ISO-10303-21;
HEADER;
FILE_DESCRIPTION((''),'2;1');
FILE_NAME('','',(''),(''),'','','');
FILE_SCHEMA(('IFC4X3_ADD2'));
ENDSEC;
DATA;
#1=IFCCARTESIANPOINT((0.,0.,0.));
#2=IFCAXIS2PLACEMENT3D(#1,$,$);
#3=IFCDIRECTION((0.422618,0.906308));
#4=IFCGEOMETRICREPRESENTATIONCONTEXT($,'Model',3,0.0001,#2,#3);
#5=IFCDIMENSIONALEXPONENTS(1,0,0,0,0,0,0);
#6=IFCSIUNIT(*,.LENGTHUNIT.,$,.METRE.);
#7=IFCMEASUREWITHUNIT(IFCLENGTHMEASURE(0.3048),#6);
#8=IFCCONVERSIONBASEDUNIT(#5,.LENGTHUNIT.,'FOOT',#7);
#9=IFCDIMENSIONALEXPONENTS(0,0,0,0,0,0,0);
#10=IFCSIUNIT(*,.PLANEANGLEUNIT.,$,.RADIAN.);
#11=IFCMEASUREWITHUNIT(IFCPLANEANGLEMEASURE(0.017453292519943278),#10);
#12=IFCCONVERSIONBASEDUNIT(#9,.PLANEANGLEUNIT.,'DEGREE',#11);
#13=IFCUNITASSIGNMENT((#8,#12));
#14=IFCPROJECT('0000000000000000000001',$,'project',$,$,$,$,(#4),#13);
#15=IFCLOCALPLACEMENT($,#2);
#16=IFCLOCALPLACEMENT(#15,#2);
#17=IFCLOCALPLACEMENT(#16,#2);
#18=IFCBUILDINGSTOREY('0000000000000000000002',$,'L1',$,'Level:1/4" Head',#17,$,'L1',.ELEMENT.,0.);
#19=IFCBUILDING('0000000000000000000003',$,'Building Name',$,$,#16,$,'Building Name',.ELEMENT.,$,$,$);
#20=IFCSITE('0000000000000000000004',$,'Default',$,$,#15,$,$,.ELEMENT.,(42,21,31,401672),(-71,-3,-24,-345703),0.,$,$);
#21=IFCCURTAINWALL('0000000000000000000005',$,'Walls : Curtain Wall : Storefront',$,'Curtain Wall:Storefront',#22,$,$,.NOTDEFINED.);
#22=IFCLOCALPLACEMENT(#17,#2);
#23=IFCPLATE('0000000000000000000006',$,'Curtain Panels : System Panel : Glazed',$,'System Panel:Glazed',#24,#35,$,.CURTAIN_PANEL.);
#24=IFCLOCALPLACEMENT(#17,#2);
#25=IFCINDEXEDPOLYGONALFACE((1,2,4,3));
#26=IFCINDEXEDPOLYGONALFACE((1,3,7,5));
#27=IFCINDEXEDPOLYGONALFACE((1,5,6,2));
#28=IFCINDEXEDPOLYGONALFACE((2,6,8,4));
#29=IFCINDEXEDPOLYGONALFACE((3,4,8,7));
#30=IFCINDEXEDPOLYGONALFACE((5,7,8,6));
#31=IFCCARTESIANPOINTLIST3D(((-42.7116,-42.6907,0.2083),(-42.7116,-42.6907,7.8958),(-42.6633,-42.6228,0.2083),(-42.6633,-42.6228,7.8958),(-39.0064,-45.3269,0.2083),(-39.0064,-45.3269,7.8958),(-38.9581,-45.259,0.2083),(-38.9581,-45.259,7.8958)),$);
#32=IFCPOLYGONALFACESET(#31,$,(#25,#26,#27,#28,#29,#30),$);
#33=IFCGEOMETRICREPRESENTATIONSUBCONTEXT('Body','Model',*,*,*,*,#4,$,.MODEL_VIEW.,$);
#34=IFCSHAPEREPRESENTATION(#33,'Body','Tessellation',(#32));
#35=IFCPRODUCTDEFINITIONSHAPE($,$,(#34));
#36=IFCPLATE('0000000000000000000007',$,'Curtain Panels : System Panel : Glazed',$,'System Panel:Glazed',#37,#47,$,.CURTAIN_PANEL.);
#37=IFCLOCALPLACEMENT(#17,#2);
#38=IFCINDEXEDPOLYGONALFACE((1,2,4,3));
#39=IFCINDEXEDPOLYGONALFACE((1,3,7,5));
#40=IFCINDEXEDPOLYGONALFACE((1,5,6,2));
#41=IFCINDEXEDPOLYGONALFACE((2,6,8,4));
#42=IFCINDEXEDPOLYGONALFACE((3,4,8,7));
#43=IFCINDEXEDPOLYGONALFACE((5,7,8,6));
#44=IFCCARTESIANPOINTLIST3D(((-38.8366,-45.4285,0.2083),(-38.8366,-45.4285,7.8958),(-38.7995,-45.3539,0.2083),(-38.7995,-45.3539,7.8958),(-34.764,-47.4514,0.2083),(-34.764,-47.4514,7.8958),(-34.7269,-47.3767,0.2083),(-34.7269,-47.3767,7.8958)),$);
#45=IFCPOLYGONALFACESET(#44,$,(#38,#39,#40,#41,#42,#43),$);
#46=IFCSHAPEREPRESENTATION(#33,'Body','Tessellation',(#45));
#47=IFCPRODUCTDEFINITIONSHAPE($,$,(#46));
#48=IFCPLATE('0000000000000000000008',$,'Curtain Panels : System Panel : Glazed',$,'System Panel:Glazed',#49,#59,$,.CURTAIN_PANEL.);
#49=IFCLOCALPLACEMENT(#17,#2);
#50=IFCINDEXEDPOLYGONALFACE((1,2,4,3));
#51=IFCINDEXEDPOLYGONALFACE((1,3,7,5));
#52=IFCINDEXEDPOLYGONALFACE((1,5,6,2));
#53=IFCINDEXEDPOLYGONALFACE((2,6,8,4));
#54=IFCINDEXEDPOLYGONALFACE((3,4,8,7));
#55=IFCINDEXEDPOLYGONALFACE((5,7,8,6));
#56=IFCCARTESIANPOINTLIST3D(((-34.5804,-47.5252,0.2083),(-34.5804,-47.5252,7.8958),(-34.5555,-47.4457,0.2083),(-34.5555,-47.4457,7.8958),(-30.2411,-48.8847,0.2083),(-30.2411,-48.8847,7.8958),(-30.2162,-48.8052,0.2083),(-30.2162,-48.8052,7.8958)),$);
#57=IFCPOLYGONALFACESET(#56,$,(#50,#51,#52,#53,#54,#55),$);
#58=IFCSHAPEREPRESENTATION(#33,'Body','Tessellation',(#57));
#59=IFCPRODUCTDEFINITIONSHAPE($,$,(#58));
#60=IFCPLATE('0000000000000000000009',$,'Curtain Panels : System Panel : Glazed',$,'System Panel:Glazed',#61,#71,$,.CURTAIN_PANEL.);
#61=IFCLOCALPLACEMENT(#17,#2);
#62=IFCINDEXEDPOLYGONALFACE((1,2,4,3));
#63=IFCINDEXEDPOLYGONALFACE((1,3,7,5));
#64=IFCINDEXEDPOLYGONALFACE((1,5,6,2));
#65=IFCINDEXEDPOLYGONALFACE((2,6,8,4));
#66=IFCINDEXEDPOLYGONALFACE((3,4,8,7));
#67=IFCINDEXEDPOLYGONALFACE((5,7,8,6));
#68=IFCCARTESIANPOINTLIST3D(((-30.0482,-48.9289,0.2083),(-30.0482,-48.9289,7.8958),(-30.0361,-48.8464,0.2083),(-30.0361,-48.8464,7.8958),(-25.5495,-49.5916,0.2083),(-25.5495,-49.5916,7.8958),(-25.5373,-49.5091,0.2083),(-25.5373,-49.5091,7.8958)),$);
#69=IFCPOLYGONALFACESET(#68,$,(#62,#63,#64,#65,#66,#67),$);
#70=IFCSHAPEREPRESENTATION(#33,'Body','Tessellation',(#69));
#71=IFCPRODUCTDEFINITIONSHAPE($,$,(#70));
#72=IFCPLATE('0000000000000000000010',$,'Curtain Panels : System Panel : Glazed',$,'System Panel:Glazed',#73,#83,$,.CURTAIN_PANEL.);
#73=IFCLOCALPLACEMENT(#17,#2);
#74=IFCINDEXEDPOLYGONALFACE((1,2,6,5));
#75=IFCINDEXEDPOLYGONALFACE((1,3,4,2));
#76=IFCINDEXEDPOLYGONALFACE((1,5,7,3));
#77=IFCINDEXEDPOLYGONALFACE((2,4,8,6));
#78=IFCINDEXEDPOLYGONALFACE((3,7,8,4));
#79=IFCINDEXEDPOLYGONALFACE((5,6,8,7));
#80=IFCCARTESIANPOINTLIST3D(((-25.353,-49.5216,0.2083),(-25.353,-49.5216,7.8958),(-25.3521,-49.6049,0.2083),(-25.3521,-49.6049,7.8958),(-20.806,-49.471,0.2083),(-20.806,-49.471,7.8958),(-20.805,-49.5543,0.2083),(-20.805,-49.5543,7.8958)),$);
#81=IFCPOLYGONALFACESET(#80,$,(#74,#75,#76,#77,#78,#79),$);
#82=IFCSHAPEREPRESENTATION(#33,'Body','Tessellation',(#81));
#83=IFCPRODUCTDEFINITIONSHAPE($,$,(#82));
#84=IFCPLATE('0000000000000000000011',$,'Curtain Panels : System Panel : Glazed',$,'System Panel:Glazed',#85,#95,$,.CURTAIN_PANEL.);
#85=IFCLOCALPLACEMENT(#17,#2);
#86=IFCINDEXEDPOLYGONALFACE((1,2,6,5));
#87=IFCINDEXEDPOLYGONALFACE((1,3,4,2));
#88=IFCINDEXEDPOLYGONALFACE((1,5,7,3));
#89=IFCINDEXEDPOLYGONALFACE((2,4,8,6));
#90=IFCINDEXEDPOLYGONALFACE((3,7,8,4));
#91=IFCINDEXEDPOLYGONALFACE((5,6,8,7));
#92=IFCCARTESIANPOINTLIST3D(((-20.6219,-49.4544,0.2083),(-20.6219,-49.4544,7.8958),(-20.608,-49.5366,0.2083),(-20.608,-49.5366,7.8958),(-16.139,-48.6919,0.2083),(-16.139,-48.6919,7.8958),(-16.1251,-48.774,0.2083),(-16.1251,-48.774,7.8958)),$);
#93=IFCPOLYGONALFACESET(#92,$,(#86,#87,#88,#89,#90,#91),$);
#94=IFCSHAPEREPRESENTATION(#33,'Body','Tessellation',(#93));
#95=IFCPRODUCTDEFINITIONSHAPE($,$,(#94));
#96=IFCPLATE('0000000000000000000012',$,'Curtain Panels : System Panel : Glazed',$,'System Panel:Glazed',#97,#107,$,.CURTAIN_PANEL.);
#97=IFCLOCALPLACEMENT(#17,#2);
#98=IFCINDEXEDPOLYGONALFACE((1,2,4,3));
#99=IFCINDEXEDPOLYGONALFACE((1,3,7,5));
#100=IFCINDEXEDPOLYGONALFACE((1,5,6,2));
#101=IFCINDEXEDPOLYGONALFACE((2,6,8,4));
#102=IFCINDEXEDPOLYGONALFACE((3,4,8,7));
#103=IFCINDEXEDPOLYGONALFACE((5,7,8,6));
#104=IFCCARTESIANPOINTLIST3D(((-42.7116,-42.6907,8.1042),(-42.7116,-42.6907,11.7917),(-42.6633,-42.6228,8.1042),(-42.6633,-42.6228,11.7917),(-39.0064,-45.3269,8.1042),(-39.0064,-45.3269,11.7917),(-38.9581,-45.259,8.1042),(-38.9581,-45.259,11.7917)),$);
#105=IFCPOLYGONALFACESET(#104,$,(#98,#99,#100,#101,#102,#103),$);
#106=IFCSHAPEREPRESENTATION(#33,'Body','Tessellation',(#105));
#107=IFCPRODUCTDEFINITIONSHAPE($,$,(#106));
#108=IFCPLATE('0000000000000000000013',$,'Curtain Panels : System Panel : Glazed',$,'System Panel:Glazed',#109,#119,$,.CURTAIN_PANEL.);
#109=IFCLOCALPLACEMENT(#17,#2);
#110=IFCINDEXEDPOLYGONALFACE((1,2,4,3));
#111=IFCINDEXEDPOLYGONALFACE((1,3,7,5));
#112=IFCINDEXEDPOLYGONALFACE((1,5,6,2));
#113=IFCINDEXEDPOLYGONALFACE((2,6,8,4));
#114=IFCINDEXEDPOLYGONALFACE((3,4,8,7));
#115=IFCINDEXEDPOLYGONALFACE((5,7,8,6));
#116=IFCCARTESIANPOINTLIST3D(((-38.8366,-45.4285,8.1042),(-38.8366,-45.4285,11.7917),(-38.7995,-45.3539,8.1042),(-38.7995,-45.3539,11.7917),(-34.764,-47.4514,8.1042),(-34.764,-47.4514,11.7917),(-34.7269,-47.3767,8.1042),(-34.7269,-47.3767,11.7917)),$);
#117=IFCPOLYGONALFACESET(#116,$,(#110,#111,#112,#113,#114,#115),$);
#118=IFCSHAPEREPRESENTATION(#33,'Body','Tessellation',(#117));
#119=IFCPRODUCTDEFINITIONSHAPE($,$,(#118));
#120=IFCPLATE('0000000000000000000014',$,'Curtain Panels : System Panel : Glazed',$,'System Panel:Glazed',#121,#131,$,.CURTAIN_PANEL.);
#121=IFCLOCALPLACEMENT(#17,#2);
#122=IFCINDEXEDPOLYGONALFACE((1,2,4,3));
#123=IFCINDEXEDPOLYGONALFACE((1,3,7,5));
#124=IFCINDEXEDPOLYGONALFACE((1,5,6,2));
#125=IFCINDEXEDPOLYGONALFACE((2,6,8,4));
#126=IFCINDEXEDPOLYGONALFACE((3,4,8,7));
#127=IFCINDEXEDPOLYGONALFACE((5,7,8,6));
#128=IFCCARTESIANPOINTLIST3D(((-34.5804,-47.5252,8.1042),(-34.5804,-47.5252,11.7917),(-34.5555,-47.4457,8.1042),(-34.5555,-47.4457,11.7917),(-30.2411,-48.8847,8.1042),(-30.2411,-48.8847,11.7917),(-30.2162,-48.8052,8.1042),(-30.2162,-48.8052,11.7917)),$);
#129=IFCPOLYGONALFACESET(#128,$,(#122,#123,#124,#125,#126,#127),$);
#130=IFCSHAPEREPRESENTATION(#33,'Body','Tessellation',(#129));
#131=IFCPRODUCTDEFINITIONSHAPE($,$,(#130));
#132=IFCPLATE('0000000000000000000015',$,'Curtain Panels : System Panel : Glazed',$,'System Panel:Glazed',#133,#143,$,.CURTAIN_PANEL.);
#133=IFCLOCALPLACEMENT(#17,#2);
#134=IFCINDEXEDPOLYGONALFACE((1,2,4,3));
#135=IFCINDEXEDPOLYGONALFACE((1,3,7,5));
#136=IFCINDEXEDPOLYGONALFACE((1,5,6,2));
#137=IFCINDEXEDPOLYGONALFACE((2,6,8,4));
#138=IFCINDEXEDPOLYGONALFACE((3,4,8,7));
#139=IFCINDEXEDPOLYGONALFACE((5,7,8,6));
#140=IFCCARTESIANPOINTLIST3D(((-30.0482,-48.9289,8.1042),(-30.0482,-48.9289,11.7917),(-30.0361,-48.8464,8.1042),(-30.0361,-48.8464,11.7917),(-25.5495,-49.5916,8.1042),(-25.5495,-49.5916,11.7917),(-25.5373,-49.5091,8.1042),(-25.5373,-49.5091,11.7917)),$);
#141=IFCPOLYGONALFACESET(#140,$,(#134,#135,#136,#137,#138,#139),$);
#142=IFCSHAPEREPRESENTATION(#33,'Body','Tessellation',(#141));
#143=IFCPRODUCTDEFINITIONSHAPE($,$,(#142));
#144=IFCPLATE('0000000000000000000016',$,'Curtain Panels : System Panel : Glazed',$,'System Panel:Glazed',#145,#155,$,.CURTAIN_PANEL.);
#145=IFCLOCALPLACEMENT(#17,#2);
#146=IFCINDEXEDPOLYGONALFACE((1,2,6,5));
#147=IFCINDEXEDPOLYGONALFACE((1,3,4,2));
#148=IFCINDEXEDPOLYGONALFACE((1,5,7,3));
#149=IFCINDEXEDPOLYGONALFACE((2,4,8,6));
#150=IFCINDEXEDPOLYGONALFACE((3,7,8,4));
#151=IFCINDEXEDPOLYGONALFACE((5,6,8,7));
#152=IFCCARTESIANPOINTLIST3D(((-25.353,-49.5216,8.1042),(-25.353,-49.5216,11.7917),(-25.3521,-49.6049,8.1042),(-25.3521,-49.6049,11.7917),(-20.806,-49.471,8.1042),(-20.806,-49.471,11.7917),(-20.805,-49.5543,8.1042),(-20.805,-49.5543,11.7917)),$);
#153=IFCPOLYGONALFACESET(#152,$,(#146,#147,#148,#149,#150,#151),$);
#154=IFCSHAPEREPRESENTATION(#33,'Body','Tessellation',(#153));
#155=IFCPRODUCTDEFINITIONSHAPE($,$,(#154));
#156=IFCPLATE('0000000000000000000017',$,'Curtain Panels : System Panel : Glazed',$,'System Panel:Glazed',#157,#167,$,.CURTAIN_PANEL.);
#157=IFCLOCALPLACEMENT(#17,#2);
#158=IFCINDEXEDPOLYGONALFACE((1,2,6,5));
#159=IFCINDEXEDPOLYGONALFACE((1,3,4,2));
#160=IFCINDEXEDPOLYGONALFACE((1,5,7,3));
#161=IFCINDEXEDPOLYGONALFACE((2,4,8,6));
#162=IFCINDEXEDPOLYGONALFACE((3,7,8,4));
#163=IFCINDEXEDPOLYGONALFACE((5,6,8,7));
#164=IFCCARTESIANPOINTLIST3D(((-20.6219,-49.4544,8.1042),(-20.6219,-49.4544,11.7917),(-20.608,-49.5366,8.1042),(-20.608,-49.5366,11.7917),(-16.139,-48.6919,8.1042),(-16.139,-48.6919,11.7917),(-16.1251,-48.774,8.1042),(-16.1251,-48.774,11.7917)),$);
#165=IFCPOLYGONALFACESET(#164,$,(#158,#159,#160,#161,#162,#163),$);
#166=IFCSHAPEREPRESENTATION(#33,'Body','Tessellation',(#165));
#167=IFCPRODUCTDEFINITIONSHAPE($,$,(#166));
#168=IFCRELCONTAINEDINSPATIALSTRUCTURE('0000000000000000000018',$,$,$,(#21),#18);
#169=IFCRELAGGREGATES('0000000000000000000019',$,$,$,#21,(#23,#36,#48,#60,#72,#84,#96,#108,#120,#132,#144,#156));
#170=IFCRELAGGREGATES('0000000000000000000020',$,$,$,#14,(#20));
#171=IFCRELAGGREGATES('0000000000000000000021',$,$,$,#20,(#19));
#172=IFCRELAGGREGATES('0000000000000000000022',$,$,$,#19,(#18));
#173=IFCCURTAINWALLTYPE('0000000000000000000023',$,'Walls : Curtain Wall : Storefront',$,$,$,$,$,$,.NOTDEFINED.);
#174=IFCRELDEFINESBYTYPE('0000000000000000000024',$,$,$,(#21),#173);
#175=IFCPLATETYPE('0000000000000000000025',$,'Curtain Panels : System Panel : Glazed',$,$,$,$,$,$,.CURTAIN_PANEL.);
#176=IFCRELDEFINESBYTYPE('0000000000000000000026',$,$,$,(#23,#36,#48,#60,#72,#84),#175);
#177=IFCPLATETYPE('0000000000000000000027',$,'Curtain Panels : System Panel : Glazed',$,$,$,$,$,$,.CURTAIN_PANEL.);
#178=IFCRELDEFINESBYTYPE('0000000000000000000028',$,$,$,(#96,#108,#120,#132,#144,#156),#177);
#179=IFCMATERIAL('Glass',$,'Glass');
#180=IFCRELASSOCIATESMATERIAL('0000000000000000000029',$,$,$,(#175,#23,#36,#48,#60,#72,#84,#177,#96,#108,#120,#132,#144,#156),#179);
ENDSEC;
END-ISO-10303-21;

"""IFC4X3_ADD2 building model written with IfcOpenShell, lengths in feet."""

from ifc_helpers import new_model, entity, si_unit, converted_unit, direction, frame, frame_2d, origin, place, context, subcontext, project, spatial, rectangle, extrude, source, transform, mapped, material, type_object, type_shapes, element, aggregate, save


model = new_model("IFC4X3_ADD2")

# Units and contexts
model_context = context("Model", 3, precision=0.0001, world=origin(), true_north=direction((0.422618, 0.906308)))
body_context = subcontext(model_context, "Body", "Model", "MODEL_VIEW")
ifc_project = project(units=[converted_unit("LENGTHUNIT", "FOOT", entity("IfcLengthMeasure", 0.3048), si_unit("LENGTHUNIT", "METRE"), dimensions=[1, 0, 0, 0, 0, 0, 0]), converted_unit("PLANEANGLEUNIT", "DEGREE", entity("IfcPlaneAngleMeasure", 0.017453292519943278), si_unit("PLANEANGLEUNIT", "RADIAN"), dimensions=[0, 0, 0, 0, 0, 0, 0])], contexts=[model_context])

# Site, building, storey
site_placement = place(None, origin())
site = spatial("IfcSite", under=ifc_project, at=site_placement, Name="Default", CompositionType="ELEMENT", RefLatitude=(42, 21, 31, 401672), RefLongitude=(-71, -3, -24, -345703), RefElevation=0.0)
building_placement = place(site_placement, origin())
building = spatial("IfcBuilding", under=site, at=building_placement, Name="Building Name", LongName="Building Name", CompositionType="ELEMENT")
storey_placement = place(building_placement, origin())
storey = spatial("IfcBuildingStorey", under=building, at=storey_placement, Name="L1", ObjectType="Level:1/4\" Head", LongName="L1", CompositionType="ELEMENT", Elevation=0.0)

# Curtain wall, plates
curtain_wall_type = type_object("IfcCurtainWallType", Name="Walls : Curtain Wall : Storefront", PredefinedType="NOTDEFINED")
curtain_wall_placement = place(storey_placement, origin())
curtain_wall = element("IfcCurtainWall", 1, at=curtain_wall_placement, inside=storey, type_object=curtain_wall_type, Name="Walls : Curtain Wall : Storefront", ObjectType="Curtain Wall:Storefront", PredefinedType="NOTDEFINED")
ifc_material_1 = material(Name="Glass", Category="Glass")
plate_type_1 = type_object("IfcPlateType", Name="Curtain Panels : System Panel : Glazed", PredefinedType="CURTAIN_PANEL", material=ifc_material_1)
shared_shape_1 = source(origin(), body_context, "Body", "SweptSolid", [
    extrude(rectangle(XDim=0.0833, YDim=4.5473, at=frame_2d((0.0, 0.0), x_axis=(1.0, 0.0))), frame((2.2737, 0.0417, 0.0), z_axis=(0.0, 0.0, 1.0), x_axis=(0.0, 1.0, 0.0)), (0.0, 0.0, 1.0), 7.6875),
])
type_shapes(plate_type_1, [shared_shape_1])
plate_1_placement = place(curtain_wall_placement, frame((-42.7116, -42.6907, 0.2083), z_axis=(0.0, 0.0, 1.0), x_axis=(0.814824, -0.579708, 0.0)))
plate_1 = element("IfcPlate", 2, at=plate_1_placement, type_object=plate_type_1, material=ifc_material_1, Name="Curtain Panels : System Panel : Glazed", ObjectType="System Panel:Glazed", PredefinedType="CURTAIN_PANEL", context=body_context, shape_type="MappedRepresentation", body=[
    mapped(shared_shape_1, transform((0.0, 0.0, 0.0), scale=1.0)),
])
plate_2_placement = place(curtain_wall_placement, frame((-38.8366, -45.4285, 0.2083), z_axis=(0.0, 0.0, 1.0), x_axis=(0.895609, -0.444842, 0.0)))
plate_2 = element("IfcPlate", 3, at=plate_2_placement, type_object=plate_type_1, material=ifc_material_1, Name="Curtain Panels : System Panel : Glazed", ObjectType="System Panel:Glazed", PredefinedType="CURTAIN_PANEL", context=body_context, shape_type="MappedRepresentation", body=[
    mapped(shared_shape_1, transform((0.0, 0.0, 0.0), scale=1.0)),
])
plate_3_placement = place(curtain_wall_placement, frame((-34.5804, -47.5252, 0.2083), z_axis=(0.0, 0.0, 1.0), x_axis=(0.954259, -0.298981, 0.0)))
plate_3 = element("IfcPlate", 4, at=plate_3_placement, type_object=plate_type_1, material=ifc_material_1, Name="Curtain Panels : System Panel : Glazed", ObjectType="System Panel:Glazed", PredefinedType="CURTAIN_PANEL", context=body_context, shape_type="MappedRepresentation", body=[
    mapped(shared_shape_1, transform((0.0, 0.0, 0.0), scale=1.0)),
])
plate_4_placement = place(curtain_wall_placement, frame((-30.0482, -48.9289, 0.2083), z_axis=(0.0, 0.0, 1.0), x_axis=(0.989324, -0.145731, 0.0)))
plate_4 = element("IfcPlate", 5, at=plate_4_placement, type_object=plate_type_1, material=ifc_material_1, Name="Curtain Panels : System Panel : Glazed", ObjectType="System Panel:Glazed", PredefinedType="CURTAIN_PANEL", context=body_context, shape_type="MappedRepresentation", body=[
    mapped(shared_shape_1, transform((0.0, 0.0, 0.0), scale=1.0)),
])
plate_5_placement = place(curtain_wall_placement, frame((-25.3521, -49.6049, 0.2083), z_axis=(0.0, 0.0, 1.0), x_axis=(0.999938, 0.011121, 0.0)))
plate_5 = element("IfcPlate", 6, at=plate_5_placement, type_object=plate_type_1, material=ifc_material_1, Name="Curtain Panels : System Panel : Glazed", ObjectType="System Panel:Glazed", PredefinedType="CURTAIN_PANEL", context=body_context, shape_type="MappedRepresentation", body=[
    mapped(shared_shape_1, transform((0.0, 0.0, 0.0), scale=1.0)),
])
plate_6_placement = place(curtain_wall_placement, frame((-20.608, -49.5366, 0.2083), z_axis=(0.0, 0.0, 1.0), x_axis=(0.985838, 0.167698, 0.0)))
plate_6 = element("IfcPlate", 7, at=plate_6_placement, type_object=plate_type_1, material=ifc_material_1, Name="Curtain Panels : System Panel : Glazed", ObjectType="System Panel:Glazed", PredefinedType="CURTAIN_PANEL", context=body_context, shape_type="MappedRepresentation", body=[
    mapped(shared_shape_1, transform((0.0, 0.0, 0.0), scale=1.0)),
])
plate_type_2 = type_object("IfcPlateType", Name="Curtain Panels : System Panel : Glazed", PredefinedType="CURTAIN_PANEL", material=ifc_material_1)
shared_shape_2 = source(origin(), body_context, "Body", "SweptSolid", [
    extrude(rectangle(XDim=0.0833, YDim=4.5473, at=frame_2d((0.0, 0.0), x_axis=(1.0, 0.0))), frame((2.2737, 0.0417, 0.0), z_axis=(0.0, 0.0, 1.0), x_axis=(0.0, 1.0, 0.0)), (0.0, 0.0, 1.0), 3.6875),
])
type_shapes(plate_type_2, [shared_shape_2])
plate_7_placement = place(curtain_wall_placement, frame((-42.7116, -42.6907, 8.1042), z_axis=(0.0, 0.0, 1.0), x_axis=(0.814824, -0.579708, 0.0)))
plate_7 = element("IfcPlate", 8, at=plate_7_placement, type_object=plate_type_2, material=ifc_material_1, Name="Curtain Panels : System Panel : Glazed", ObjectType="System Panel:Glazed", PredefinedType="CURTAIN_PANEL", context=body_context, shape_type="MappedRepresentation", body=[
    mapped(shared_shape_2, transform((0.0, 0.0, 0.0), scale=1.0)),
])
plate_8_placement = place(curtain_wall_placement, frame((-38.8366, -45.4285, 8.1042), z_axis=(0.0, 0.0, 1.0), x_axis=(0.895609, -0.444842, 0.0)))
plate_8 = element("IfcPlate", 9, at=plate_8_placement, type_object=plate_type_2, material=ifc_material_1, Name="Curtain Panels : System Panel : Glazed", ObjectType="System Panel:Glazed", PredefinedType="CURTAIN_PANEL", context=body_context, shape_type="MappedRepresentation", body=[
    mapped(shared_shape_2, transform((0.0, 0.0, 0.0), scale=1.0)),
])
plate_9_placement = place(curtain_wall_placement, frame((-34.5804, -47.5252, 8.1042), z_axis=(0.0, 0.0, 1.0), x_axis=(0.954259, -0.298981, 0.0)))
plate_9 = element("IfcPlate", 10, at=plate_9_placement, type_object=plate_type_2, material=ifc_material_1, Name="Curtain Panels : System Panel : Glazed", ObjectType="System Panel:Glazed", PredefinedType="CURTAIN_PANEL", context=body_context, shape_type="MappedRepresentation", body=[
    mapped(shared_shape_2, transform((0.0, 0.0, 0.0), scale=1.0)),
])
plate_10_placement = place(curtain_wall_placement, frame((-30.0482, -48.9289, 8.1042), z_axis=(0.0, 0.0, 1.0), x_axis=(0.989324, -0.145731, 0.0)))
plate_10 = element("IfcPlate", 11, at=plate_10_placement, type_object=plate_type_2, material=ifc_material_1, Name="Curtain Panels : System Panel : Glazed", ObjectType="System Panel:Glazed", PredefinedType="CURTAIN_PANEL", context=body_context, shape_type="MappedRepresentation", body=[
    mapped(shared_shape_2, transform((0.0, 0.0, 0.0), scale=1.0)),
])
plate_11_placement = place(curtain_wall_placement, frame((-25.3521, -49.6049, 8.1042), z_axis=(0.0, 0.0, 1.0), x_axis=(0.999938, 0.011121, 0.0)))
plate_11 = element("IfcPlate", 12, at=plate_11_placement, type_object=plate_type_2, material=ifc_material_1, Name="Curtain Panels : System Panel : Glazed", ObjectType="System Panel:Glazed", PredefinedType="CURTAIN_PANEL", context=body_context, shape_type="MappedRepresentation", body=[
    mapped(shared_shape_2, transform((0.0, 0.0, 0.0), scale=1.0)),
])
plate_12_placement = place(curtain_wall_placement, frame((-20.608, -49.5366, 8.1042), z_axis=(0.0, 0.0, 1.0), x_axis=(0.985838, 0.167698, 0.0)))
plate_12 = element("IfcPlate", 13, at=plate_12_placement, type_object=plate_type_2, material=ifc_material_1, Name="Curtain Panels : System Panel : Glazed", ObjectType="System Panel:Glazed", PredefinedType="CURTAIN_PANEL", context=body_context, shape_type="MappedRepresentation", body=[
    mapped(shared_shape_2, transform((0.0, 0.0, 0.0), scale=1.0)),
])
aggregate(curtain_wall, [plate_1, plate_2, plate_3, plate_4, plate_5, plate_6, plate_7, plate_8, plate_9, plate_10, plate_11, plate_12])

save(model, "model.ifc")
